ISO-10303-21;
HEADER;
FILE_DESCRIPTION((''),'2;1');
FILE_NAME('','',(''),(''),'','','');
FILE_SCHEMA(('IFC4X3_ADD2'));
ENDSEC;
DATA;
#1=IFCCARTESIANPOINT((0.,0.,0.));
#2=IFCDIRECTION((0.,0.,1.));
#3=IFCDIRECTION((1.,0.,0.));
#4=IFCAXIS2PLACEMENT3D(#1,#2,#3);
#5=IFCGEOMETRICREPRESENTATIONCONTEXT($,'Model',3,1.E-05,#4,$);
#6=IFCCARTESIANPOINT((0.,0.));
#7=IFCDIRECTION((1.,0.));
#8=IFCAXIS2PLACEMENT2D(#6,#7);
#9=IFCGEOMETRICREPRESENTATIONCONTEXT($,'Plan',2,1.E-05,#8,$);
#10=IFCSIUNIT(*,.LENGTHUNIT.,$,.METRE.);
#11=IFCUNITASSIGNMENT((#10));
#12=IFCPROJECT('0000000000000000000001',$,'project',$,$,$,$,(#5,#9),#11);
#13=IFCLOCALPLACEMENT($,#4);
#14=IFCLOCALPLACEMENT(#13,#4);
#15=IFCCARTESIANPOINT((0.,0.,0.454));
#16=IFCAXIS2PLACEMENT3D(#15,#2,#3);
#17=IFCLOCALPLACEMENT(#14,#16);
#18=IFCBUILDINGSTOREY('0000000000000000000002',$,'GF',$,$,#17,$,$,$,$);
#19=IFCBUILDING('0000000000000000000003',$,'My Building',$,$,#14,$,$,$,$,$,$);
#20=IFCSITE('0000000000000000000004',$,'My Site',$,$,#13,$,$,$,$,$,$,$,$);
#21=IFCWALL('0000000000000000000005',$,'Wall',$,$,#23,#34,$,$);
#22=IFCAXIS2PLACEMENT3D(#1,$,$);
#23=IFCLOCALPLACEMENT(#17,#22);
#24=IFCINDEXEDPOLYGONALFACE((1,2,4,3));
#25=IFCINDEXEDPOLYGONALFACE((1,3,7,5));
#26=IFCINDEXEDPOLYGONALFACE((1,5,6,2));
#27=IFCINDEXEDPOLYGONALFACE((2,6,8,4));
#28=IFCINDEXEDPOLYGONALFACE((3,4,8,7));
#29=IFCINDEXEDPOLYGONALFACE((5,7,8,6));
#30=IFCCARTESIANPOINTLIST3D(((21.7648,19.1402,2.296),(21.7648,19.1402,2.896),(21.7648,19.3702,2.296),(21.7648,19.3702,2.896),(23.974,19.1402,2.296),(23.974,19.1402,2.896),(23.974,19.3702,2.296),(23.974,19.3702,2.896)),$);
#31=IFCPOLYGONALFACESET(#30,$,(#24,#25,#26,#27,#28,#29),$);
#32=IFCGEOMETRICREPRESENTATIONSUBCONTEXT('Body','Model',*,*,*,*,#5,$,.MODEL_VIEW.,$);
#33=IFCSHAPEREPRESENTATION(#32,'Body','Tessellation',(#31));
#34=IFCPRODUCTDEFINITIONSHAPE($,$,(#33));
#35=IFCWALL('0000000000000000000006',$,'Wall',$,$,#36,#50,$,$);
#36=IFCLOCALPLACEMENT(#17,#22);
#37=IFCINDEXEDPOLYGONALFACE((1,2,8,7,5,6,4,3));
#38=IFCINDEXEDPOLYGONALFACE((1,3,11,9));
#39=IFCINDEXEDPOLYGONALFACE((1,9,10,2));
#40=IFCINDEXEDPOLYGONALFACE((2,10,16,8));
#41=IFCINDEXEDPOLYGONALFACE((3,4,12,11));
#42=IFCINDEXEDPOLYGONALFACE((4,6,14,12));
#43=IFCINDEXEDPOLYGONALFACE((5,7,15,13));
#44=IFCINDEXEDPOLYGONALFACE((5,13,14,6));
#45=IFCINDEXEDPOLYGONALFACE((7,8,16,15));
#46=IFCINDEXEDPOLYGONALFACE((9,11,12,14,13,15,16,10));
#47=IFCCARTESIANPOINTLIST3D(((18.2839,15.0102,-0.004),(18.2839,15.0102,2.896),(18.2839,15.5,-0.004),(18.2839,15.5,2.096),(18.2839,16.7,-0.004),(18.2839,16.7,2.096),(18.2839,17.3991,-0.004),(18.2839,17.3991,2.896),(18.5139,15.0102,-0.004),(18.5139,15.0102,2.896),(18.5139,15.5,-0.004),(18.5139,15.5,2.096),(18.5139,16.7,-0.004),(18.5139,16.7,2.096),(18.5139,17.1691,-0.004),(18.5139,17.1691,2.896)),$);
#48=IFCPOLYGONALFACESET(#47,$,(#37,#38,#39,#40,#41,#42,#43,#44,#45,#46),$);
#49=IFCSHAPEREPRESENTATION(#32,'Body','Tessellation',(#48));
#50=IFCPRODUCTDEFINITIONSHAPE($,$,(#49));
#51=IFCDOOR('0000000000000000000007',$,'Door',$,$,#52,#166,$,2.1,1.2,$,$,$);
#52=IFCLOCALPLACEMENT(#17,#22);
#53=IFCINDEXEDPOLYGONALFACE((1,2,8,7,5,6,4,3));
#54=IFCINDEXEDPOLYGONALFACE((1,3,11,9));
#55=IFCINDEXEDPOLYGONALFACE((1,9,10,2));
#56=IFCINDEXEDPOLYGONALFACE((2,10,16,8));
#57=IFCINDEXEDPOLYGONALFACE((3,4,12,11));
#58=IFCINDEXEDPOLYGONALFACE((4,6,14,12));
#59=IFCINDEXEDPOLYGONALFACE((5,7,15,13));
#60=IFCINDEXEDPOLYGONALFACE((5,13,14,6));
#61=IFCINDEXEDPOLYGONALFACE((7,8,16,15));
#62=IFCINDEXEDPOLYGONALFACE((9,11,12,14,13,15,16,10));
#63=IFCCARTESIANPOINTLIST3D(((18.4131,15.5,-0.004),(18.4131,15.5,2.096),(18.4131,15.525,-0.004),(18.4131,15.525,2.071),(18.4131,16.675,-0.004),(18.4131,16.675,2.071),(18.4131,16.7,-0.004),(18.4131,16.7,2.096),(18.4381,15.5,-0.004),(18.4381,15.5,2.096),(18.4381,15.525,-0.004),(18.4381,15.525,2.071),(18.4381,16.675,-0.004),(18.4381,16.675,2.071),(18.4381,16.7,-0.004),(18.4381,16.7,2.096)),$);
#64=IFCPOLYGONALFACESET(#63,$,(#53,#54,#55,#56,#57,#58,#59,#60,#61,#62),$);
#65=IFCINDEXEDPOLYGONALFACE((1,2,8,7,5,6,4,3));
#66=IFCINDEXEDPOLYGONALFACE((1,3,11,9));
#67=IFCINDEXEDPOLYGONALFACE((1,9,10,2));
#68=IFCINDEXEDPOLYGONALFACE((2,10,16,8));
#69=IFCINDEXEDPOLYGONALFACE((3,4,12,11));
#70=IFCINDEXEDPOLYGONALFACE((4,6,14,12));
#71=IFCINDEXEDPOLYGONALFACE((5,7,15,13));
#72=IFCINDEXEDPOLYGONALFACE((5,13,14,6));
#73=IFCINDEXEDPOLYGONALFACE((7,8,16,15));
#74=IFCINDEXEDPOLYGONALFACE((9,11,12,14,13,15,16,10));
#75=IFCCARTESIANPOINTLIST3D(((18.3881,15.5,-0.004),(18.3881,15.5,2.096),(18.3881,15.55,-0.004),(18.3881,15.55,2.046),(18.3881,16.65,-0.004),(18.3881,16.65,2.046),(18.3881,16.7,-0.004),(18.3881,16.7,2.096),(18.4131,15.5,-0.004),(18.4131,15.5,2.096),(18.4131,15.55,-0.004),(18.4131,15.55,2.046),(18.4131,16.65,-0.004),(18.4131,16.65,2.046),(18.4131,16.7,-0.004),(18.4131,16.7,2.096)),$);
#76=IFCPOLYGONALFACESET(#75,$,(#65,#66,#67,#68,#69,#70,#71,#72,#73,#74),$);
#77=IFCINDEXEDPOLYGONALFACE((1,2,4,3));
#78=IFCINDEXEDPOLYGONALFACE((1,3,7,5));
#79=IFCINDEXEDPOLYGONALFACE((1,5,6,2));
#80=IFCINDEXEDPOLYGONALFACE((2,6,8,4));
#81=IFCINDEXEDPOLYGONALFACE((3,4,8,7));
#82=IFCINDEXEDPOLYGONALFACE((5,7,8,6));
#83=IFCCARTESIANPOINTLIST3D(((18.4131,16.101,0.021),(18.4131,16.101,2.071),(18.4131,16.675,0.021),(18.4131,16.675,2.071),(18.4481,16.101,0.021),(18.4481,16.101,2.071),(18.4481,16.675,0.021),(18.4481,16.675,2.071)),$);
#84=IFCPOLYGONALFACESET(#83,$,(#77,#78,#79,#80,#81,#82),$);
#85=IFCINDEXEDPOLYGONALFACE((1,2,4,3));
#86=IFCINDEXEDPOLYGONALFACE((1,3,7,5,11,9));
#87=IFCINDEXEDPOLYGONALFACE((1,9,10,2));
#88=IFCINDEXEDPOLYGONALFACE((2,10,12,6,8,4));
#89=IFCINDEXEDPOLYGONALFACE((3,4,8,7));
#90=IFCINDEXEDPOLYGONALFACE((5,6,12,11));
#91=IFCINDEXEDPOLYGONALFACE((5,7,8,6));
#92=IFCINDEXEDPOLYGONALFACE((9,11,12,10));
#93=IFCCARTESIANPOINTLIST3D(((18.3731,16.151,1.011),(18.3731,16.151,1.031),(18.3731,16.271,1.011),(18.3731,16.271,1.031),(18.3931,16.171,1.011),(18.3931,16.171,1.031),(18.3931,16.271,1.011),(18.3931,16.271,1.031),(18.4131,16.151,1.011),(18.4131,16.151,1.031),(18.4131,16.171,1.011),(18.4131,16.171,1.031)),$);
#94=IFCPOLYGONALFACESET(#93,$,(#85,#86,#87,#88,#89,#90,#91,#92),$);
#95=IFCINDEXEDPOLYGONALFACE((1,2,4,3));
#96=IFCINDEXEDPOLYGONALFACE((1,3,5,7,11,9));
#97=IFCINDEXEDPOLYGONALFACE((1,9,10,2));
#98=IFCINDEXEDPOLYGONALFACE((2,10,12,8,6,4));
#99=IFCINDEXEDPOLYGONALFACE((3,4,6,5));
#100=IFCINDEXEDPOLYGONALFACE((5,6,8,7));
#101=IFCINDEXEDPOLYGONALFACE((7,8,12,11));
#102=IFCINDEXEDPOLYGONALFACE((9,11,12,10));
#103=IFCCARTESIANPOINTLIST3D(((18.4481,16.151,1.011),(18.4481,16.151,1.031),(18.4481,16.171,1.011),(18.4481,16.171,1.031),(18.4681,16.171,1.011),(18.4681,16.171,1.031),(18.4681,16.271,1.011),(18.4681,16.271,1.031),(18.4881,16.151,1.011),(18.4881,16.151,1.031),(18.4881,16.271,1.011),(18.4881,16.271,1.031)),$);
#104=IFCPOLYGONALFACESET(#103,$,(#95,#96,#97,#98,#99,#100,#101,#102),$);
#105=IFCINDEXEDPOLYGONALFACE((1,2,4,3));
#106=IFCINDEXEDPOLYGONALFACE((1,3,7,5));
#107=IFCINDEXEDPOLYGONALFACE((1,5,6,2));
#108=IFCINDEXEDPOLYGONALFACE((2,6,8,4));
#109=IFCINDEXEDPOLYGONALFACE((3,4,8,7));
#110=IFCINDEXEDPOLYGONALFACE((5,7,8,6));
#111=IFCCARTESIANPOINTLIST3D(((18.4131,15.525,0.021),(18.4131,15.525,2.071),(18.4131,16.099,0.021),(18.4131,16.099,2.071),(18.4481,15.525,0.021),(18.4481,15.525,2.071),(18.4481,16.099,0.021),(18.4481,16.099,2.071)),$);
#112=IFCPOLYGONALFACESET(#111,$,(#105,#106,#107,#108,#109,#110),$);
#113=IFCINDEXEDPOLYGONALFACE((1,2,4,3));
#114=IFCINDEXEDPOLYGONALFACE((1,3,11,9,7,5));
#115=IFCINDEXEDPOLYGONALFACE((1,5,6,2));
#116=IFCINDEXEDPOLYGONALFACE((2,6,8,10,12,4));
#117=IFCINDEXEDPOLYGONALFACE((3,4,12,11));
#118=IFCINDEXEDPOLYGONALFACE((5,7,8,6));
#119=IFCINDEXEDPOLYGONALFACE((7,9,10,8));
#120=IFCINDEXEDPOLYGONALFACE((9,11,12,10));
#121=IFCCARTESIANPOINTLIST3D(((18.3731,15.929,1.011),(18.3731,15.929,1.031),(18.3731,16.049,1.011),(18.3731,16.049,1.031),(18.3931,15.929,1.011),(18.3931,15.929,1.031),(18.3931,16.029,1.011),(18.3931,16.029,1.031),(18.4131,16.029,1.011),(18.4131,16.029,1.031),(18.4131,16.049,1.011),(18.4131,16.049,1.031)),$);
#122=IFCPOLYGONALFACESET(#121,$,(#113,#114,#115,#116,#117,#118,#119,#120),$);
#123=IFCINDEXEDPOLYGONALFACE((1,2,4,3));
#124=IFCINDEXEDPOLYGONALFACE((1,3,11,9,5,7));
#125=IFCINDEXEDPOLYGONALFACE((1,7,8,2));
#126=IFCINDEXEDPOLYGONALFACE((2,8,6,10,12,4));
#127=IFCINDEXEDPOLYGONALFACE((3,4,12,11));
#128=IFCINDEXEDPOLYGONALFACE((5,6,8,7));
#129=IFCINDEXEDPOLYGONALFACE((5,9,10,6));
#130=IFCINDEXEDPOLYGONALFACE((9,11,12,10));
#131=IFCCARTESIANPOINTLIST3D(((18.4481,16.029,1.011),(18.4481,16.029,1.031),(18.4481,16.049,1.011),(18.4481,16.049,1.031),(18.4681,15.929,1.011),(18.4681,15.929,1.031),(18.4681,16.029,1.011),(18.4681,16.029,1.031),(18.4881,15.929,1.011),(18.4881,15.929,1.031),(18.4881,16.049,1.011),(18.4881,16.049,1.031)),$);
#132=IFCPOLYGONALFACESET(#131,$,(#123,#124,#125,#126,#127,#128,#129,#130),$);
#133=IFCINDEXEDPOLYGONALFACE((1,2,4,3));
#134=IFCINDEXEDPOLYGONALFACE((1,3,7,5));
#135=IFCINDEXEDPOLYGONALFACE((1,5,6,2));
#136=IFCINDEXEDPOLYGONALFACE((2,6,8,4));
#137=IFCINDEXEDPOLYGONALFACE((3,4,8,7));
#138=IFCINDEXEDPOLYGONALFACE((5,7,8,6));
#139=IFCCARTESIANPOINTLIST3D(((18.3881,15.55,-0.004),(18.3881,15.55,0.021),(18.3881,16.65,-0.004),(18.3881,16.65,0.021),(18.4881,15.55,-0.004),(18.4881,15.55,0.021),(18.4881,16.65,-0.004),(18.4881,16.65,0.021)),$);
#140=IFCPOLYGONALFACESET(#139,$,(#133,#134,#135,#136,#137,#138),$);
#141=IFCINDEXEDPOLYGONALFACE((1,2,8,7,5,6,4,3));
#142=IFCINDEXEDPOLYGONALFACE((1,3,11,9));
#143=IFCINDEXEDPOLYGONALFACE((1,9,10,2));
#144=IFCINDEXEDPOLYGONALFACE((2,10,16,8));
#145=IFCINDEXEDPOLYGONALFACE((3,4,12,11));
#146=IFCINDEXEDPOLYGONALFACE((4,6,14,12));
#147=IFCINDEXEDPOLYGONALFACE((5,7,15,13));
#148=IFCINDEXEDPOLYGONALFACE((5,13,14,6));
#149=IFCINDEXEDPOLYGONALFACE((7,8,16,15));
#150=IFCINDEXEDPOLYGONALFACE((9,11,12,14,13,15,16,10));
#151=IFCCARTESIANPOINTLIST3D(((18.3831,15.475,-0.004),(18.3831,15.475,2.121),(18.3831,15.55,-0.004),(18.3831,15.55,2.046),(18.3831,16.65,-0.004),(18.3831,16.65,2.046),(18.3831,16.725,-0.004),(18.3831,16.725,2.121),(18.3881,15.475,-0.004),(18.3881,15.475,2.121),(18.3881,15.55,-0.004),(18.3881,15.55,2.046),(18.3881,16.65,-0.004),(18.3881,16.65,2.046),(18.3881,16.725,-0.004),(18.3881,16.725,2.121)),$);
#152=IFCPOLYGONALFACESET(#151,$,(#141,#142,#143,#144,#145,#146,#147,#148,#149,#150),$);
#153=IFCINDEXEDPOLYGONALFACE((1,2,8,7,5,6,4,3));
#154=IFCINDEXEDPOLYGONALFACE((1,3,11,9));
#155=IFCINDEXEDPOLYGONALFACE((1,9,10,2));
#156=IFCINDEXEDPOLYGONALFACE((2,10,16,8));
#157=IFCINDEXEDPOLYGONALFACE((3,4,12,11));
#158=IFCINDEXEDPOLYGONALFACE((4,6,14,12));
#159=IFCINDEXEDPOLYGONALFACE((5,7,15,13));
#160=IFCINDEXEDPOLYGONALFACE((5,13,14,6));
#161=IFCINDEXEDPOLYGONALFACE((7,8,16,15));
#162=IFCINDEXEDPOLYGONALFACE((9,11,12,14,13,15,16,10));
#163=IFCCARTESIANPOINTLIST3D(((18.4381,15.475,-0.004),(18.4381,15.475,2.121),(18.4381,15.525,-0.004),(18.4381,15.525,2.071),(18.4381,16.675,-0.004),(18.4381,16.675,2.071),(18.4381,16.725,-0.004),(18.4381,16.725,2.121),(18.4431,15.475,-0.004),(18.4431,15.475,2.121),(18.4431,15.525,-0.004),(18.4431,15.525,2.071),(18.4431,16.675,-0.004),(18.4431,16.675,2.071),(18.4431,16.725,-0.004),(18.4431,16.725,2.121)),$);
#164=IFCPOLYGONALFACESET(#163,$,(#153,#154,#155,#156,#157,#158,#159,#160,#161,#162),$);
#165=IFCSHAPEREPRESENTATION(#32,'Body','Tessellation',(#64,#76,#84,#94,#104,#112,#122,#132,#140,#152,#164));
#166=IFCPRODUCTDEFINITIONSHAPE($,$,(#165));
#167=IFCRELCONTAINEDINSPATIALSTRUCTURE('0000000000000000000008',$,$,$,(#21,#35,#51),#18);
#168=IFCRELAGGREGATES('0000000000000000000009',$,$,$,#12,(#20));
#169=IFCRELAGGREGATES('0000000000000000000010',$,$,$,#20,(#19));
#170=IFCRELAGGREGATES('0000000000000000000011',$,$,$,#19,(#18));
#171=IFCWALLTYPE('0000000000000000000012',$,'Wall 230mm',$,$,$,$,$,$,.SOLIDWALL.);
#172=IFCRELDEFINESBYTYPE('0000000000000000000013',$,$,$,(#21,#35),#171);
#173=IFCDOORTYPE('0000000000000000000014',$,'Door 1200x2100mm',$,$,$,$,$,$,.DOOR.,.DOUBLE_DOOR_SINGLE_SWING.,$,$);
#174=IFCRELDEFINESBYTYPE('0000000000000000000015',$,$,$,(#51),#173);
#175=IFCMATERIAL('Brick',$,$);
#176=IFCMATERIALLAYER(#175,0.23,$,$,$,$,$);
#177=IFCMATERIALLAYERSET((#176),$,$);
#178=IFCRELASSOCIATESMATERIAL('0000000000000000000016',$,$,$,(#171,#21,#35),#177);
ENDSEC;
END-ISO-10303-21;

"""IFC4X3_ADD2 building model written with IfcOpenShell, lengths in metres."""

from ifc_helpers import new_model, entity, si_unit, frame, origin_with_axes, origin_2d_with_axis, place, context, subcontext, project, spatial, line, indexed_curve, outline, extrude, clip, halfspace, shape, source, transform, mapped, material, layer, layer_set, layer_usage, type_object, type_shapes, element, fill, save


model = new_model("IFC4X3_ADD2")

# Units and contexts
model_context = context("Model", 3, precision=1e-05, world=origin_with_axes())
plan_context = context("Plan", 2, precision=1e-05, world=origin_2d_with_axis())
body_context_1 = subcontext(model_context, "Body", "Model", "MODEL_VIEW")
body_context_2 = subcontext(plan_context, "Body", "Plan", "PLAN_VIEW")
ifc_project = project(units=[si_unit("LENGTHUNIT", "METRE")], contexts=[model_context, plan_context])

# Site, building, storey
site_placement = place(None, origin_with_axes())
site = spatial("IfcSite", under=ifc_project, at=site_placement, Name="My Site")
building_placement = place(site_placement, origin_with_axes())
building = spatial("IfcBuilding", under=site, at=building_placement, Name="My Building")
storey_placement = place(building_placement, frame((0.0, 0.0, 0.454), z_axis=(0.0, 0.0, 1.0), x_axis=(1.0, 0.0, 0.0)))
storey = spatial("IfcBuildingStorey", under=building, at=storey_placement, Name="GF")

# Shared definitions
ifc_material_1 = material(Name="Brick")

# Wall
ifc_layer_1 = layer(ifc_material_1, 0.23)
ifc_layer_set_1 = layer_set([ifc_layer_1])
wall_type_1 = type_object("IfcWallType", Name="Wall 230mm", PredefinedType="SOLIDWALL", material=ifc_layer_set_1)
ifc_layer_usage_1 = layer_usage(ifc_layer_set_1, "AXIS2", "POSITIVE", 0.0)
wall_1_placement = place(storey_placement, frame((23.974, 19.3702, 2.296), z_axis=(0.0, 0.0, 1.0), x_axis=(-1.0, 0.0, 0.0)))
element("IfcWall", 1, at=wall_1_placement, inside=storey, type_object=wall_type_1, material=ifc_layer_usage_1, Name="Wall", context=body_context_1, shape_type="SweptSolid", body=[
    extrude(outline(indexed_curve([(0.0, 0.0), (0.0, 0.23), (2.2092, 0.23), (2.2092, 0.0), (0.0, 0.0)], self_intersect=False)), origin_with_axes(), (0.0, 0.0, 1.0), 0.6),
])

# Wall, opening, door
ifc_layer_usage_2 = layer_usage(ifc_layer_set_1, "AXIS2", "POSITIVE", 0.0)
wall_2_placement = place(storey_placement, frame((18.5139, 15.0102, -0.004), z_axis=(0.0, 0.0, 1.0), x_axis=(0.000001, 1.0, 0.0)))
wall_2 = element("IfcWall", 2, at=wall_2_placement, inside=storey, type_object=wall_type_1, material=ifc_layer_usage_2, Name="Wall", context=body_context_1, shape_type="Clipping", body=[
    clip(extrude(outline(indexed_curve([(0.0, 0.0), (0.0, 0.23), (2.3889, 0.23), (2.3889, 0.0), (0.0, 0.0)], self_intersect=False)), origin_with_axes(), (0.0, 0.0, 1.0), 2.9), halfspace(frame((2.1589, 0.0, -0.45), z_axis=(0.666999, -0.666998, 0.0), x_axis=(-0.707106, -0.707107, 0.0)), False)),
])
shared_shape_1 = source(origin_with_axes(), body_context_1, "Body", "SweptSolid", [
    extrude(outline(indexed_curve([(0.0, 0.0), (1.2, 0.0), (1.2, 2.1), (0.0, 2.1)], segments=[line(1, 2, 3, 4, 1)])), frame((0.0, -0.6, 0.0), z_axis=(0.0, -1.0, 0.0), x_axis=(1.0, 0.0, 0.0)), (0.0, 0.0, -1.0), 1.2),
])
opening_1_placement = place(wall_2_placement, frame((0.4898, 0.0, 0.0), z_axis=(0.0, 0.0, 1.0), x_axis=(1.0, 0.0, 0.0)))
opening_1 = element("IfcOpeningElement", 3, at=opening_1_placement, cuts=wall_2, PredefinedType="OPENING", context=body_context_1, shape_type="MappedRepresentation", body=[
    mapped(shared_shape_1, transform((0.0, 0.0, 0.0), x_axis=(1.0, 0.0, 0.0), y_axis=(0.0, 1.0, 0.0), z_axis=(0.0, 0.0, 1.0), scale=1.0)),
])
door_type_1 = type_object("IfcDoorType", Name="Door 1200x2100mm", OperationType="DOUBLE_DOOR_SINGLE_SWING", PredefinedType="DOOR")
shared_shape_2 = source(origin_with_axes(), body_context_1, "Body", "SweptSolid", [
    extrude(outline(indexed_curve([(0.0, 0.0), (0.0, 2.1), (1.2, 2.1), (1.2, 0.0), (1.175, 0.0), (1.175, 2.075), (0.025, 2.075), (0.025, 0.0)], segments=[line(1, 2, 3, 4, 5, 6, 7, 8, 1)])), frame((0.0, 0.025, 0.0), z_axis=(0.0, -1.0, 0.0), x_axis=(1.0, 0.0, 0.0)), (0.0, 0.0, -1.0), 0.025),
    extrude(outline(indexed_curve([(0.0, 0.0), (0.0, 2.1), (1.2, 2.1), (1.2, 0.0), (1.15, 0.0), (1.15, 2.05), (0.05, 2.05), (0.05, 0.0)], segments=[line(1, 2, 3, 4, 5, 6, 7, 8, 1)])), frame((0.0, 0.0, 0.0), z_axis=(0.0, -1.0, 0.0), x_axis=(1.0, 0.0, 0.0)), (0.0, 0.0, -1.0), 0.025),
    extrude(outline(indexed_curve([(0.0, 0.0), (0.574, 0.0), (0.574, 0.035), (0.0, 0.035)], segments=[line(1, 2, 3, 4, 1)])), frame((0.025, 0.025, 0.025), z_axis=(0.0, 0.0, 1.0), x_axis=(1.0, 0.0, 0.0)), (0.0, 0.0, 1.0), 2.05),
    extrude(outline(indexed_curve([(0.0, 0.0), (0.0, -0.04), (-0.12, -0.04), (-0.12, -0.02), (-0.02, -0.02), (-0.02, 0.0)], segments=[line(1, 2, 3, 4, 5, 6, 1)])), frame((0.549, 0.025, 1.015), z_axis=(0.0, 0.0, 1.0), x_axis=(1.0, 0.0, 0.0)), (0.0, 0.0, 1.0), 0.02),
    extrude(outline(indexed_curve([(0.0, 0.0), (0.0, 0.04), (-0.12, 0.04), (-0.12, 0.02), (-0.02, 0.02), (-0.02, 0.0)], segments=[line(1, 2, 3, 4, 5, 6, 1)])), frame((0.549, 0.06, 1.015), z_axis=(0.0, 0.0, 1.0), x_axis=(1.0, 0.0, 0.0)), (0.0, 0.0, 1.0), 0.02),
    extrude(outline(indexed_curve([(0.0, 0.0), (-0.574, 0.0), (-0.574, 0.035), (0.0, 0.035)], segments=[line(1, 2, 3, 4, 1)])), frame((1.175, 0.025, 0.025), z_axis=(0.0, 0.0, 1.0), x_axis=(1.0, 0.0, 0.0)), (0.0, 0.0, 1.0), 2.05),
    extrude(outline(indexed_curve([(0.0, 0.0), (0.0, -0.04), (0.12, -0.04), (0.12, -0.02), (0.02, -0.02), (0.02, 0.0)], segments=[line(1, 2, 3, 4, 5, 6, 1)])), frame((0.651, 0.025, 1.015), z_axis=(0.0, 0.0, 1.0), x_axis=(1.0, 0.0, 0.0)), (0.0, 0.0, 1.0), 0.02),
    extrude(outline(indexed_curve([(0.0, 0.0), (0.0, 0.04), (0.12, 0.04), (0.12, 0.02), (0.02, 0.02), (0.02, 0.0)], segments=[line(1, 2, 3, 4, 5, 6, 1)])), frame((0.651, 0.06, 1.015), z_axis=(0.0, 0.0, 1.0), x_axis=(1.0, 0.0, 0.0)), (0.0, 0.0, 1.0), 0.02),
    extrude(outline(indexed_curve([(0.0, 0.0), (1.1, 0.0), (1.1, 0.1), (0.0, 0.1)], segments=[line(1, 2, 3, 4, 1)])), frame((0.05, 0.0, 0.0), z_axis=(0.0, 0.0, 1.0), x_axis=(1.0, 0.0, 0.0)), (0.0, 0.0, 1.0), 0.025),
    extrude(outline(indexed_curve([(0.0, 0.0), (0.0, 2.125), (1.25, 2.125), (1.25, 0.0), (1.175, 0.0), (1.175, 2.05), (0.075, 2.05), (0.075, 0.0)], segments=[line(1, 2, 3, 4, 5, 6, 7, 8, 1)])), frame((-0.025, -0.005, 0.0), z_axis=(0.0, -1.0, 0.0), x_axis=(1.0, 0.0, 0.0)), (0.0, 0.0, -1.0), 0.005),
    extrude(outline(indexed_curve([(0.0, 0.0), (0.0, 2.125), (1.25, 2.125), (1.25, 0.0), (1.2, 0.0), (1.2, 2.075), (0.05, 2.075), (0.05, 0.0)], segments=[line(1, 2, 3, 4, 5, 6, 7, 8, 1)])), frame((-0.025, 0.05, 0.0), z_axis=(0.0, -1.0, 0.0), x_axis=(1.0, 0.0, 0.0)), (0.0, 0.0, -1.0), 0.005),
])
shared_shape_3 = source(origin_with_axes(), body_context_2, "Body", "Curve2D", [
    entity("IfcIndexedPolyCurve", entity("IfcCartesianPointList2D", [[0.0, 0.0], [0.0, 0.05], [0.025, 0.05], [0.025, 0.025], [0.05, 0.025], [0.05, 0.0]]), [entity("IfcLineIndex", [1, 2, 3, 4, 5, 6, 1])]),
    entity("IfcIndexedPolyCurve", entity("IfcCartesianPointList2D", [[1.2, 0.0], [1.2, 0.05], [1.175, 0.05], [1.175, 0.025], [1.15, 0.025], [1.15, 0.0]]), [entity("IfcLineIndex", [1, 2, 3, 4, 5, 6, 1])]),
    entity("IfcTrimmedCurve", entity("IfcEllipse", entity("IfcAxis2Placement2D", entity("IfcCartesianPoint", [0.06, 0.05]), entity("IfcDirection", [1.0, 0.0])), 0.54, 0.575), [entity("IfcCartesianPoint", [0.6, 0.05])], [entity("IfcCartesianPoint", [0.06, 0.625])], True, "CARTESIAN"),
    entity("IfcIndexedPolyCurve", entity("IfcCartesianPointList2D", [[0.025, 0.05], [0.06, 0.05], [0.06, 0.625], [0.025, 0.625]]), [entity("IfcLineIndex", [1, 2, 3, 4, 1])]),
    entity("IfcTrimmedCurve", entity("IfcEllipse", entity("IfcAxis2Placement2D", entity("IfcCartesianPoint", [1.14, 0.05]), entity("IfcDirection", [1.0, 0.0])), 0.54, 0.575), [entity("IfcCartesianPoint", [1.14, 0.625])], [entity("IfcCartesianPoint", [0.6, 0.05])], True, "CARTESIAN"),
    entity("IfcIndexedPolyCurve", entity("IfcCartesianPointList2D", [[1.175, 0.05], [1.14, 0.05], [1.14, 0.625], [1.175, 0.625]]), [entity("IfcLineIndex", [1, 2, 3, 4, 1])]),
])
type_shapes(door_type_1, [shared_shape_2, shared_shape_3])
door_1_placement = place(opening_1_placement, frame((1.2, 0.1258, 0.0), z_axis=(0.0, 0.0, 1.0), x_axis=(-1.0, 0.0, 0.0)))
door_1 = element("IfcDoor", 4, at=door_1_placement, inside=storey, type_object=door_type_1, Name="Door", OverallHeight=2.1, OverallWidth=1.2, shapes=[
    shape(body_context_1, "Body", "MappedRepresentation", [mapped(shared_shape_2, transform((0.0, 0.0, 0.0), x_axis=(1.0, 0.0, 0.0), y_axis=(0.0, 1.0, 0.0), z_axis=(0.0, 0.0, 1.0), scale=1.0))]),
    shape(body_context_2, "Body", "MappedRepresentation", [mapped(shared_shape_3, transform((0.0, 0.0, 0.0), x_axis=(1.0, 0.0, 0.0), y_axis=(0.0, 1.0, 0.0), z_axis=(0.0, 0.0, 1.0), scale=1.0))]),
])
fill(opening_1, door_1)

save(model, "model.ifc")
